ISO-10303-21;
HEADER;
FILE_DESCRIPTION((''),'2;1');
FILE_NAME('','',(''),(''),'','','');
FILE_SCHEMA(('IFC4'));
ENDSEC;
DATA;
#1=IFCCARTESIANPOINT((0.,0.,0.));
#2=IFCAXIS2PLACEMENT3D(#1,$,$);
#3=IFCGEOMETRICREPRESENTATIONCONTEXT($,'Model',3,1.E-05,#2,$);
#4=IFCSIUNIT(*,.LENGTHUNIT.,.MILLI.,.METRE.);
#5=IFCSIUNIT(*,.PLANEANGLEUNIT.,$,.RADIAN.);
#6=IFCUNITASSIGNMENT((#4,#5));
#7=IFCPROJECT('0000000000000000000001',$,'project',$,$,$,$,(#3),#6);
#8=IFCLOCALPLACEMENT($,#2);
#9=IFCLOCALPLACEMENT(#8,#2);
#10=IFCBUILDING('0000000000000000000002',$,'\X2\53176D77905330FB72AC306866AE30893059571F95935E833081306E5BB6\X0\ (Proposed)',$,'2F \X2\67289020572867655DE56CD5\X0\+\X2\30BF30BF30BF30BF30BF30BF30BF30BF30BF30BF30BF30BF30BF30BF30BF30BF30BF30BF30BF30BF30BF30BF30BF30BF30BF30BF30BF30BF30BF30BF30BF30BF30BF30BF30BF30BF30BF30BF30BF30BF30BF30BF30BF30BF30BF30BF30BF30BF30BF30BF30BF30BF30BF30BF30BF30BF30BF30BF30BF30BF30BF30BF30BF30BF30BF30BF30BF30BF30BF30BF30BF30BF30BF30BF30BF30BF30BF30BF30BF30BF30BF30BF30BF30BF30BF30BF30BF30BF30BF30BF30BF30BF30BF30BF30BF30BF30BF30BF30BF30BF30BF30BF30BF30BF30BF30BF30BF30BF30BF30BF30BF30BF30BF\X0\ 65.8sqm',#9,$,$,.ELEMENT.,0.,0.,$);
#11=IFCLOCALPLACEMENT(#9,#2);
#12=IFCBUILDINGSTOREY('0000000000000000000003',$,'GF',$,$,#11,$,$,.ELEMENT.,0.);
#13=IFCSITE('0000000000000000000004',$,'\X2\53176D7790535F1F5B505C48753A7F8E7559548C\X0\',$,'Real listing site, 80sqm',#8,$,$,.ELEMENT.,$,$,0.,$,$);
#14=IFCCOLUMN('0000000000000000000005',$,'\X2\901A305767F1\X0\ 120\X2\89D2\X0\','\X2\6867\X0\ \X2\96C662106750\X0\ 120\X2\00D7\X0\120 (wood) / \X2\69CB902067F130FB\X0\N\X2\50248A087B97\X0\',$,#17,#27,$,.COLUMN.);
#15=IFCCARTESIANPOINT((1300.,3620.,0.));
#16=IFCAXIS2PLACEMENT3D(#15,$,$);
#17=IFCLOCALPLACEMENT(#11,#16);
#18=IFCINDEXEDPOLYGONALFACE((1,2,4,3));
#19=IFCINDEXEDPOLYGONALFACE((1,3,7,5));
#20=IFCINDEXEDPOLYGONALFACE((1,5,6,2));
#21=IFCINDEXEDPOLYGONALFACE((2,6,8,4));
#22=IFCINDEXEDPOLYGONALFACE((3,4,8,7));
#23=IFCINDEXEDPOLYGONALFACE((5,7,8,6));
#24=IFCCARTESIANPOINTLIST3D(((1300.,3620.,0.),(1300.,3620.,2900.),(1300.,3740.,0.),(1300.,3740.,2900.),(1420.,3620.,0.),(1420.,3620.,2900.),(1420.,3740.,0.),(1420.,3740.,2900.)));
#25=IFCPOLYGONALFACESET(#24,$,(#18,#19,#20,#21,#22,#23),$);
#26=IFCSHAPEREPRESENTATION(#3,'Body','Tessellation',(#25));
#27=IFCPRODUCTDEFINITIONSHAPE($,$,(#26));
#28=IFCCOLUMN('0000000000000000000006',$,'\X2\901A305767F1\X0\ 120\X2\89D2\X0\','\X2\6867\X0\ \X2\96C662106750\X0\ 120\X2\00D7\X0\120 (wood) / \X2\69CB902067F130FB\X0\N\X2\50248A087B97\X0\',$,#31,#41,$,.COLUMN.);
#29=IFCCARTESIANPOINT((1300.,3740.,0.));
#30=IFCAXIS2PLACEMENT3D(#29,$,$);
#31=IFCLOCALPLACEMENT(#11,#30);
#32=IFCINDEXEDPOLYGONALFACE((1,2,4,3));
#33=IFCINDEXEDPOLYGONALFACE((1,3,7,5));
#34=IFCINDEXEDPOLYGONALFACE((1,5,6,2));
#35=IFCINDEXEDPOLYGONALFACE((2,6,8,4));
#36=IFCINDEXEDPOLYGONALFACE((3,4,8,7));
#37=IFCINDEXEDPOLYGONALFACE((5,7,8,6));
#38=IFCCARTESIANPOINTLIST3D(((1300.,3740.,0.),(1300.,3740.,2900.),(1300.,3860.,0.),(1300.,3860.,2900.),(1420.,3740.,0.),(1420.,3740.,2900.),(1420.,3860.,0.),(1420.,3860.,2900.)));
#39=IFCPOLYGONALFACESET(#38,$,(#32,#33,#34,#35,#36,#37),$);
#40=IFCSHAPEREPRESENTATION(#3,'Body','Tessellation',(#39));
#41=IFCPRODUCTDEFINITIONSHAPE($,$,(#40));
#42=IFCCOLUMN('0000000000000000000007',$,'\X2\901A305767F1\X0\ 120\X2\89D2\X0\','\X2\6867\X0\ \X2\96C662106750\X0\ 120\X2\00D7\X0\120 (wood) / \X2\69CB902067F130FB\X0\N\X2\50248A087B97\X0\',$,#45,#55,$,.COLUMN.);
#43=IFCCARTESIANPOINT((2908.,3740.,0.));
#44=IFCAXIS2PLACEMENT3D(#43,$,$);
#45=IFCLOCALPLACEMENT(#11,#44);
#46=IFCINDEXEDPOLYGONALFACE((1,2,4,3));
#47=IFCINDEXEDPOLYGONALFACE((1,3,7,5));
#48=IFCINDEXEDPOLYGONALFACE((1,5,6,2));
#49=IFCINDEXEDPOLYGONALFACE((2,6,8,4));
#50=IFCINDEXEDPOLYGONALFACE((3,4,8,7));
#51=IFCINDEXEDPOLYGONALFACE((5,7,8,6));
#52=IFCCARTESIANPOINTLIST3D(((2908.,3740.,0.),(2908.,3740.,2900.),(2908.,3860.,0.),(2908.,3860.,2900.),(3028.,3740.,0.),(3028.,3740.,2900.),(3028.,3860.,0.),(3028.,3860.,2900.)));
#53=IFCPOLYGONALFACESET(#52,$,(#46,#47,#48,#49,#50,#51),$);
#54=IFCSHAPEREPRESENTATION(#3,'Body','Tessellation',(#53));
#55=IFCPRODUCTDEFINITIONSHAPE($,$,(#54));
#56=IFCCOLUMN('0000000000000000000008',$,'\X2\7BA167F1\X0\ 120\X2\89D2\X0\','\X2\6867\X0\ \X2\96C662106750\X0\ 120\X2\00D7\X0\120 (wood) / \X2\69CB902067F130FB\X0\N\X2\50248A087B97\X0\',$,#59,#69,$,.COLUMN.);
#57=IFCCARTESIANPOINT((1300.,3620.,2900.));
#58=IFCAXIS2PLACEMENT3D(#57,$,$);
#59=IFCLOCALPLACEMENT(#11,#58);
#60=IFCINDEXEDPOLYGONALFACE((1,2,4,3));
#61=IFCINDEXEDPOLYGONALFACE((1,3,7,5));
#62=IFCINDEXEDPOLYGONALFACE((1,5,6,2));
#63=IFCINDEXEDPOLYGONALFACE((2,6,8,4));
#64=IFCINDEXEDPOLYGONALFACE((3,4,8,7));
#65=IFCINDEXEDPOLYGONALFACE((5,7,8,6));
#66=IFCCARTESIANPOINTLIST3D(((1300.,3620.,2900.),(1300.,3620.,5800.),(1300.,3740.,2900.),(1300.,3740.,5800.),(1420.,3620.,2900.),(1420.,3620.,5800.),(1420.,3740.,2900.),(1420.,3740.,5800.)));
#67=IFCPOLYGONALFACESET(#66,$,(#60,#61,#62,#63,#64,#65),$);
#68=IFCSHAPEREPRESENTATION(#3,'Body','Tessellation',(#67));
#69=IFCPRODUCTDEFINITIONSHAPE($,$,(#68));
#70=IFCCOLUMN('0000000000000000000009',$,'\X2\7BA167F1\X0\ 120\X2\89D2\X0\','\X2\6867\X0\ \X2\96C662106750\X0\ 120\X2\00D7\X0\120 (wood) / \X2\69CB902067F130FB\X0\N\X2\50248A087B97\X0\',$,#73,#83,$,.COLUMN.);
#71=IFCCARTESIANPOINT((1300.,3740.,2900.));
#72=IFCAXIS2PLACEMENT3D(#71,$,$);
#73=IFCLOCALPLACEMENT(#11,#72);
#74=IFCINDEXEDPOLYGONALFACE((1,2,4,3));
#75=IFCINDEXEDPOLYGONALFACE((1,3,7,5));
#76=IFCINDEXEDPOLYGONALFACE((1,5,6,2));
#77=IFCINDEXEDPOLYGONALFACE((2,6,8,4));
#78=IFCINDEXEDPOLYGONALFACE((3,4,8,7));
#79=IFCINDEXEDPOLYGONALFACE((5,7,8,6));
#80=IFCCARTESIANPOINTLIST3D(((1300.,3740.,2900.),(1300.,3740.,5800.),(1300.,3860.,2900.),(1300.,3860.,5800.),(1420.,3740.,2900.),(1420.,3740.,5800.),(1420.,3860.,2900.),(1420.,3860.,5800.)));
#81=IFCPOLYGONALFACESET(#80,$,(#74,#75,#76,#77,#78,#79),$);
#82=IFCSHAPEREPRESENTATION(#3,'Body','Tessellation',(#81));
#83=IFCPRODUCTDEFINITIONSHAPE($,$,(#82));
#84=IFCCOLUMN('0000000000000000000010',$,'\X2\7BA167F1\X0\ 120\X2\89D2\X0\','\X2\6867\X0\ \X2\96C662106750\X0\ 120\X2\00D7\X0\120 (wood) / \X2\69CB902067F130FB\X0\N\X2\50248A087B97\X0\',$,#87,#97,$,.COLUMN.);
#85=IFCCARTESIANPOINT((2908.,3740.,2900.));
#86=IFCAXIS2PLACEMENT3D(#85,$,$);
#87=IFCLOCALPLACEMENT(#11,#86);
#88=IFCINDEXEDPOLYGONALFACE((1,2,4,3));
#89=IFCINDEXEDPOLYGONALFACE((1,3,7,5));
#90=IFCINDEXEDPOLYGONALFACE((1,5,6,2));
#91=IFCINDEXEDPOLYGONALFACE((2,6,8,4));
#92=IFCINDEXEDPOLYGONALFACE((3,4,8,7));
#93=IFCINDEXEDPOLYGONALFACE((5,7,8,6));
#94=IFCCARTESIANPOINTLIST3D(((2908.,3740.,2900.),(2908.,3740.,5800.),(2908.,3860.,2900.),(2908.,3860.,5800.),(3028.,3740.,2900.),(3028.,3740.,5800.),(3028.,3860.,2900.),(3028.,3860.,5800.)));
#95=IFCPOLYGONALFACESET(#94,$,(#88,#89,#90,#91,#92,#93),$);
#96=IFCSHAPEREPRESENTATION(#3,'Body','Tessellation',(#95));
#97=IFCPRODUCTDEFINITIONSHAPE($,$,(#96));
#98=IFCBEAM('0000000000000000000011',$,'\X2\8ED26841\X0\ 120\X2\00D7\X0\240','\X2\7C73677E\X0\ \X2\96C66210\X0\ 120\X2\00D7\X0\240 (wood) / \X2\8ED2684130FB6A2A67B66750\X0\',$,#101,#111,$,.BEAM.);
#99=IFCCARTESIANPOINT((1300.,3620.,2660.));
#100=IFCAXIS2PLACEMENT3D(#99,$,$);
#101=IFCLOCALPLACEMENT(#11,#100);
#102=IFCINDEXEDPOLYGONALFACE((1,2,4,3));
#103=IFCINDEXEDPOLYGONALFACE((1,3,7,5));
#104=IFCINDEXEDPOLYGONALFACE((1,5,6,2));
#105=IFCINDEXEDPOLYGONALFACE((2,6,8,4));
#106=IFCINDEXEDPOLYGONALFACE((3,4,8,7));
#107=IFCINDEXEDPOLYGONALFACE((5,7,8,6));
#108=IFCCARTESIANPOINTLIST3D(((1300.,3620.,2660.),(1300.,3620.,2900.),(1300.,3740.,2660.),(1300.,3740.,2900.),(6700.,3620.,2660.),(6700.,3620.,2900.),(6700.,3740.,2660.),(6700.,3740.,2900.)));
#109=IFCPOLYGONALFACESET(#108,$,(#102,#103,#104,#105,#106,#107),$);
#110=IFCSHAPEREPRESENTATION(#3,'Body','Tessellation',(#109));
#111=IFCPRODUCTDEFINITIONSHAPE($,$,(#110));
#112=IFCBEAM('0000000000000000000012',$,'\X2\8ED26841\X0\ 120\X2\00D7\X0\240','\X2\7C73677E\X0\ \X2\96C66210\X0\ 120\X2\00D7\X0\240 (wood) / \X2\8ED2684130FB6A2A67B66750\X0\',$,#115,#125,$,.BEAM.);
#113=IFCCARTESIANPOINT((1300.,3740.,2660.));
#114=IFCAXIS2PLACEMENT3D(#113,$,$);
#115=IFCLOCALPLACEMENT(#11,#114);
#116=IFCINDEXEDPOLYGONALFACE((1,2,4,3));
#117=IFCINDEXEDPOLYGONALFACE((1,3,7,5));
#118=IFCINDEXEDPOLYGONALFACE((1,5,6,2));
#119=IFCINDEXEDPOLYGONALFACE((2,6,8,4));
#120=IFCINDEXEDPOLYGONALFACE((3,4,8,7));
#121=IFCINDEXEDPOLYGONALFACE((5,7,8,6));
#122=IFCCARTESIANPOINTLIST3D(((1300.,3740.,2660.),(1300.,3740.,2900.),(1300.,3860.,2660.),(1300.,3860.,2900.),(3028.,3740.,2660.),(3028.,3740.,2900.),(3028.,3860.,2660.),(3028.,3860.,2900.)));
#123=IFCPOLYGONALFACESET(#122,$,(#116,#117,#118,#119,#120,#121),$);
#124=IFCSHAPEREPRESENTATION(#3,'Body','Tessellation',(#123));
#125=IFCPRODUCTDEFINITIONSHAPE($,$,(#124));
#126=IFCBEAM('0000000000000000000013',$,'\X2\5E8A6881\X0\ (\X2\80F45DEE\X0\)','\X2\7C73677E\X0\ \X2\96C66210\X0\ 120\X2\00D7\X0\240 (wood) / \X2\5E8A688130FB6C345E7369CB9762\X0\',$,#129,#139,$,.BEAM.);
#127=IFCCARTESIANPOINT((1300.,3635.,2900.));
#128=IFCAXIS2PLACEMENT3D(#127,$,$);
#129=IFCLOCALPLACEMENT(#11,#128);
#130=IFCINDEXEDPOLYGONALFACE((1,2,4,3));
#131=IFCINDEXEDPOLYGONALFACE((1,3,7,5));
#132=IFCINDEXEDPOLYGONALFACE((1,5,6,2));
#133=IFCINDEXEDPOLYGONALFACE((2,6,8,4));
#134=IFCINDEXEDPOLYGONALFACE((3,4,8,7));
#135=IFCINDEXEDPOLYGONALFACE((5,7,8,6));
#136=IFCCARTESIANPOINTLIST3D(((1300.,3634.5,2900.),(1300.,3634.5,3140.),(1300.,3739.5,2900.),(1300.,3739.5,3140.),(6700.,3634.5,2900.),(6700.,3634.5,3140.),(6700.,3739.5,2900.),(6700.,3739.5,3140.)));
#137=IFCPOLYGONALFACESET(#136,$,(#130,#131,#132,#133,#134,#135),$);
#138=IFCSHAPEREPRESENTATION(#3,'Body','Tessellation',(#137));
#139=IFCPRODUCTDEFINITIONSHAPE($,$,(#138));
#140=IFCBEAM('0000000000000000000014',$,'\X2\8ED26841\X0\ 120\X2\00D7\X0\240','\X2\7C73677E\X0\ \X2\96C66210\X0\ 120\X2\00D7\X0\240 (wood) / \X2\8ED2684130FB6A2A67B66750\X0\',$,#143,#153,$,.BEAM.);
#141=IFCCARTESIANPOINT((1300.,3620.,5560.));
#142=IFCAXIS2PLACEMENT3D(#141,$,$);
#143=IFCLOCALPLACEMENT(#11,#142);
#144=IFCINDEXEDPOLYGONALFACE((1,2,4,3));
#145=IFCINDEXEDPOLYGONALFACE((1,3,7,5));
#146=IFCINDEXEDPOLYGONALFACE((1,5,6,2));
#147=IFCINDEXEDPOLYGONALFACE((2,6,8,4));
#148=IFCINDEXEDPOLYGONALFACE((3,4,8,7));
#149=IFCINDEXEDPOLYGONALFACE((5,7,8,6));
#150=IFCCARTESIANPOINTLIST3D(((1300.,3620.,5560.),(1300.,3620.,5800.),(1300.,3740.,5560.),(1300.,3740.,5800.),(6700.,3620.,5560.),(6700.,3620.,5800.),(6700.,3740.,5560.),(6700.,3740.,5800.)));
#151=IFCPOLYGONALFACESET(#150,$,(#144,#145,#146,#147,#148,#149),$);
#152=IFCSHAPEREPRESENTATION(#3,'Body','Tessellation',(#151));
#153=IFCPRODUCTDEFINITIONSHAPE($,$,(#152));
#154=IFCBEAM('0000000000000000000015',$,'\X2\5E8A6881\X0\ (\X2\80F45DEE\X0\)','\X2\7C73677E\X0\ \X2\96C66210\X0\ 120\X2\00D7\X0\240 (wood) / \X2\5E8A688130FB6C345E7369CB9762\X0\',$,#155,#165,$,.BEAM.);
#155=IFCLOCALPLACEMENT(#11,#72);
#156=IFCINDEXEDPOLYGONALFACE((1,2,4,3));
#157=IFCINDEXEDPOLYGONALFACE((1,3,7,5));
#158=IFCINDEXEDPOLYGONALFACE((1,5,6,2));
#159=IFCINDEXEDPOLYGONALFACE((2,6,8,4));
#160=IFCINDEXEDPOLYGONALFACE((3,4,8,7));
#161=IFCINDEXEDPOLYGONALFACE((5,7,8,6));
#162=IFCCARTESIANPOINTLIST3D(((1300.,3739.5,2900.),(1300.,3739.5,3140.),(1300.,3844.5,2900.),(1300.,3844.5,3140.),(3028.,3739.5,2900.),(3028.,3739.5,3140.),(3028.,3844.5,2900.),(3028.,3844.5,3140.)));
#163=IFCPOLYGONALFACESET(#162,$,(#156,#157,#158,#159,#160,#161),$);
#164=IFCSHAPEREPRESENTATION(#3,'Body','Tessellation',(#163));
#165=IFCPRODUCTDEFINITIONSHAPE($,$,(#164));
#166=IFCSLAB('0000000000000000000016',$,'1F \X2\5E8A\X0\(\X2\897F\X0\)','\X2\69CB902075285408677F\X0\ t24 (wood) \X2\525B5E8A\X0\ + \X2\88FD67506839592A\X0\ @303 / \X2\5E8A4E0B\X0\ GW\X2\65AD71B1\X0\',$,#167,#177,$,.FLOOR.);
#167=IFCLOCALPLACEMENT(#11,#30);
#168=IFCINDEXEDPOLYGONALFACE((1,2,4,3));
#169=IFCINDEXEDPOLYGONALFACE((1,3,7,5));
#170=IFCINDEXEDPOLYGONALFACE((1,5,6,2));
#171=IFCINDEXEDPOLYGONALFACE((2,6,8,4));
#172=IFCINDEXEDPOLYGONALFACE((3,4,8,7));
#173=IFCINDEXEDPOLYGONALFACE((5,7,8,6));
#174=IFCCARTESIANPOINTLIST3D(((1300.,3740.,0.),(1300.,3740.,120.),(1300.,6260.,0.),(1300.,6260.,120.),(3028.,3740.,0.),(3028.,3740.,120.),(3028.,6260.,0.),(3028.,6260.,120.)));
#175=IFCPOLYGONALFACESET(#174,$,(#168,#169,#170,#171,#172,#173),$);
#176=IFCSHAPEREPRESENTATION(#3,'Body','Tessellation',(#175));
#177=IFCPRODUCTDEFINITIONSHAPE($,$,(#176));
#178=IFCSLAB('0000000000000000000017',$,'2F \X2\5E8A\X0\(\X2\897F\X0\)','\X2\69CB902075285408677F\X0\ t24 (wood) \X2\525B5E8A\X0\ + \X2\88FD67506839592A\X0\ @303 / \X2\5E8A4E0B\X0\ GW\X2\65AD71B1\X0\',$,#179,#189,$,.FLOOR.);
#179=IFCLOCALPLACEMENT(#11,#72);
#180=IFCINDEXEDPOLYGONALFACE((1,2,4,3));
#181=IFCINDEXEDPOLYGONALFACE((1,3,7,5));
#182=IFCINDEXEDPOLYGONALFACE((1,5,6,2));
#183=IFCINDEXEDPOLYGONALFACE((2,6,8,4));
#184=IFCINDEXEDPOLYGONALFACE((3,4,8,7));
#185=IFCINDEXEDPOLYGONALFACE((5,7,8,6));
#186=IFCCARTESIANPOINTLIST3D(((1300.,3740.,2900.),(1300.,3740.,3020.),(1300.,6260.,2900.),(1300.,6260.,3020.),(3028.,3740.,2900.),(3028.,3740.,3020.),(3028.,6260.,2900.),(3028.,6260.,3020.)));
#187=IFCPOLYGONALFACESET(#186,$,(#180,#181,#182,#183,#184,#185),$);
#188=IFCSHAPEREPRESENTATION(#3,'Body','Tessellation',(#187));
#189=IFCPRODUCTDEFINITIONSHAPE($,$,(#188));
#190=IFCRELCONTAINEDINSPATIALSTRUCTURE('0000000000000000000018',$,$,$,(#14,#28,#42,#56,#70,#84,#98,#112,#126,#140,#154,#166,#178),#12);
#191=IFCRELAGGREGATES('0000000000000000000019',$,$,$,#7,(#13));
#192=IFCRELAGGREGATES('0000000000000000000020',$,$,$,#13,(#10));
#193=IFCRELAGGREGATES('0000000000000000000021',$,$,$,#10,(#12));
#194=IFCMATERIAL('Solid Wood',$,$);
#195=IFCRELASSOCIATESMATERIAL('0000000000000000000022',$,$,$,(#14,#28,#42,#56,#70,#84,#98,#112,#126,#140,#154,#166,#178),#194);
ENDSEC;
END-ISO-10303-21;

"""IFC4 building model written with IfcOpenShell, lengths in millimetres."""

from ifc_helpers import new_model, si_unit, frame, frame_2d, origin, place, context, project, spatial, rectangle, extrude, material, element, save


model = new_model("IFC4")

# Units and contexts
model_context = context("Model", 3, precision=1e-05, world=origin())
ifc_project = project(units=[si_unit("LENGTHUNIT", "METRE", prefix="MILLI"), si_unit("PLANEANGLEUNIT", "RADIAN")], contexts=[model_context])

# Site, building, storey
site_placement = place(None, origin())
site = spatial("IfcSite", under=ifc_project, at=site_placement, Name="北海道弟子屈町美留和", ObjectType="Real listing site, 80sqm", CompositionType="ELEMENT", RefElevation=0.0)
building_placement = place(site_placement, origin())
building = spatial("IfcBuilding", under=site, at=building_placement, Name="北海道・犬と暮らす土間広めの家 (Proposed)", ObjectType="2F 木造在来工法+タタタタタタタタタタタタタタタタタタタタタタタタタタタタタタタタタタタタタタタタタタタタタタタタタタタタタタタタタタタタタタタタタタタタタタタタタタタタタタタタタタタタタタタタタタタタタタタタタタタタタタタタタタタタタタタタタ 65.8sqm", CompositionType="ELEMENT", ElevationOfRefHeight=0.0, ElevationOfTerrain=0.0)
storey_placement = place(building_placement, origin())
storey = spatial("IfcBuildingStorey", under=building, at=storey_placement, Name="GF", CompositionType="ELEMENT", Elevation=0.0)

# Columns
ifc_material_1 = material(Name="Solid Wood")
column_1_placement = place(storey_placement, frame((1300.0, 3620.0, 0.0)))
element("IfcColumn", 1, at=column_1_placement, inside=storey, material=ifc_material_1, Name="通し柱 120角", Description="桧 集成材 120×120 (wood) / 構造柱・N値計算", PredefinedType="COLUMN", context=model_context, shape_type="SweptSolid", body=[
    extrude(rectangle(XDim=120.0, YDim=120.0, at=frame_2d((60.0, 60.0))), frame((1300.0, 3620.0, 0.0)), (0.0, 0.0, 1.0), 2900.0),
])
column_2_placement = place(storey_placement, frame((1300.0, 3740.0, 0.0)))
element("IfcColumn", 2, at=column_2_placement, inside=storey, material=ifc_material_1, Name="通し柱 120角", Description="桧 集成材 120×120 (wood) / 構造柱・N値計算", PredefinedType="COLUMN", context=model_context, shape_type="SweptSolid", body=[
    extrude(rectangle(XDim=120.0, YDim=120.0, at=frame_2d((60.0, 60.0))), frame((1300.0, 3740.0, 0.0)), (0.0, 0.0, 1.0), 2900.0),
])
column_3_placement = place(storey_placement, frame((2908.0, 3740.0, 0.0)))
element("IfcColumn", 3, at=column_3_placement, inside=storey, material=ifc_material_1, Name="通し柱 120角", Description="桧 集成材 120×120 (wood) / 構造柱・N値計算", PredefinedType="COLUMN", context=model_context, shape_type="SweptSolid", body=[
    extrude(rectangle(XDim=120.0, YDim=120.0, at=frame_2d((60.0, 60.0))), frame((2908.0, 3740.0, 0.0)), (0.0, 0.0, 1.0), 2900.0),
])
column_4_placement = place(storey_placement, frame((1300.0, 3620.0, 2900.0)))
element("IfcColumn", 4, at=column_4_placement, inside=storey, material=ifc_material_1, Name="管柱 120角", Description="桧 集成材 120×120 (wood) / 構造柱・N値計算", PredefinedType="COLUMN", context=model_context, shape_type="SweptSolid", body=[
    extrude(rectangle(XDim=120.0, YDim=120.0, at=frame_2d((60.0, 60.0))), frame((1300.0, 3620.0, 2900.0)), (0.0, 0.0, 1.0), 2900.0),
])
column_5_placement = place(storey_placement, frame((1300.0, 3740.0, 2900.0)))
element("IfcColumn", 5, at=column_5_placement, inside=storey, material=ifc_material_1, Name="管柱 120角", Description="桧 集成材 120×120 (wood) / 構造柱・N値計算", PredefinedType="COLUMN", context=model_context, shape_type="SweptSolid", body=[
    extrude(rectangle(XDim=120.0, YDim=120.0, at=frame_2d((60.0, 60.0))), frame((1300.0, 3740.0, 2900.0)), (0.0, 0.0, 1.0), 2900.0),
])
column_6_placement = place(storey_placement, frame((2908.0, 3740.0, 2900.0)))
element("IfcColumn", 6, at=column_6_placement, inside=storey, material=ifc_material_1, Name="管柱 120角", Description="桧 集成材 120×120 (wood) / 構造柱・N値計算", PredefinedType="COLUMN", context=model_context, shape_type="SweptSolid", body=[
    extrude(rectangle(XDim=120.0, YDim=120.0, at=frame_2d((60.0, 60.0))), frame((2908.0, 3740.0, 2900.0)), (0.0, 0.0, 1.0), 2900.0),
])

# Beams
beam_1_placement = place(storey_placement, frame((1300.0, 3620.0, 2660.0)))
element("IfcBeam", 7, at=beam_1_placement, inside=storey, material=ifc_material_1, Name="軒桁 120×240", Description="米松 集成 120×240 (wood) / 軒桁・横架材", PredefinedType="BEAM", context=model_context, shape_type="SweptSolid", body=[
    extrude(rectangle(XDim=5400.0, YDim=120.0, at=frame_2d((2700.0, 60.0))), frame((1300.0, 3620.0, 2660.0)), (0.0, 0.0, 1.0), 240.0),
])
beam_2_placement = place(storey_placement, frame((1300.0, 3740.0, 2660.0)))
element("IfcBeam", 8, at=beam_2_placement, inside=storey, material=ifc_material_1, Name="軒桁 120×240", Description="米松 集成 120×240 (wood) / 軒桁・横架材", PredefinedType="BEAM", context=model_context, shape_type="SweptSolid", body=[
    extrude(rectangle(XDim=1728.0, YDim=120.0, at=frame_2d((864.0, 60.0))), frame((1300.0, 3740.0, 2660.0)), (0.0, 0.0, 1.0), 240.0),
])
beam_3_placement = place(storey_placement, frame((1300.0, 3635.0, 2900.0)))
element("IfcBeam", 9, at=beam_3_placement, inside=storey, material=ifc_material_1, Name="床梁 (胴差)", Description="米松 集成 120×240 (wood) / 床梁・水平構面", PredefinedType="BEAM", context=model_context, shape_type="SweptSolid", body=[
    extrude(rectangle(XDim=5400.0, YDim=105.0, at=frame_2d((2700.0, 52.0))), frame((1300.0, 3635.0, 2900.0)), (0.0, 0.0, 1.0), 240.0),
])
beam_4_placement = place(storey_placement, frame((1300.0, 3620.0, 5560.0)))
element("IfcBeam", 10, at=beam_4_placement, inside=storey, material=ifc_material_1, Name="軒桁 120×240", Description="米松 集成 120×240 (wood) / 軒桁・横架材", PredefinedType="BEAM", context=model_context, shape_type="SweptSolid", body=[
    extrude(rectangle(XDim=5400.0, YDim=120.0, at=frame_2d((2700.0, 60.0))), frame((1300.0, 3620.0, 5560.0)), (0.0, 0.0, 1.0), 240.0),
])
beam_5_placement = place(storey_placement, frame((1300.0, 3740.0, 2900.0)))
element("IfcBeam", 11, at=beam_5_placement, inside=storey, material=ifc_material_1, Name="床梁 (胴差)", Description="米松 集成 120×240 (wood) / 床梁・水平構面", PredefinedType="BEAM", context=model_context, shape_type="SweptSolid", body=[
    extrude(rectangle(XDim=1728.0, YDim=105.0, at=frame_2d((864.0, 52.0))), frame((1300.0, 3740.0, 2900.0)), (0.0, 0.0, 1.0), 240.0),
])

# Slabs
slab_1_placement = place(storey_placement, frame((1300.0, 3740.0, 0.0)))
element("IfcSlab", 12, at=slab_1_placement, inside=storey, material=ifc_material_1, Name="1F 床(西)", Description="構造用合板 t24 (wood) 剛床 + 製材根太 @303 / 床下 GW断熱", PredefinedType="FLOOR", context=model_context, shape_type="SweptSolid", body=[
    extrude(rectangle(XDim=1728.0, YDim=2520.0, at=frame_2d((864.0, 1260.0))), frame((1300.0, 3740.0, 0.0)), (0.0, 0.0, 1.0), 120.0),
])
slab_2_placement = place(storey_placement, frame((1300.0, 3740.0, 2900.0)))
element("IfcSlab", 13, at=slab_2_placement, inside=storey, material=ifc_material_1, Name="2F 床(西)", Description="構造用合板 t24 (wood) 剛床 + 製材根太 @303 / 床下 GW断熱", PredefinedType="FLOOR", context=model_context, shape_type="SweptSolid", body=[
    extrude(rectangle(XDim=1728.0, YDim=2520.0, at=frame_2d((864.0, 1260.0))), frame((1300.0, 3740.0, 2900.0)), (0.0, 0.0, 1.0), 120.0),
])

save(model, "model.ifc")
